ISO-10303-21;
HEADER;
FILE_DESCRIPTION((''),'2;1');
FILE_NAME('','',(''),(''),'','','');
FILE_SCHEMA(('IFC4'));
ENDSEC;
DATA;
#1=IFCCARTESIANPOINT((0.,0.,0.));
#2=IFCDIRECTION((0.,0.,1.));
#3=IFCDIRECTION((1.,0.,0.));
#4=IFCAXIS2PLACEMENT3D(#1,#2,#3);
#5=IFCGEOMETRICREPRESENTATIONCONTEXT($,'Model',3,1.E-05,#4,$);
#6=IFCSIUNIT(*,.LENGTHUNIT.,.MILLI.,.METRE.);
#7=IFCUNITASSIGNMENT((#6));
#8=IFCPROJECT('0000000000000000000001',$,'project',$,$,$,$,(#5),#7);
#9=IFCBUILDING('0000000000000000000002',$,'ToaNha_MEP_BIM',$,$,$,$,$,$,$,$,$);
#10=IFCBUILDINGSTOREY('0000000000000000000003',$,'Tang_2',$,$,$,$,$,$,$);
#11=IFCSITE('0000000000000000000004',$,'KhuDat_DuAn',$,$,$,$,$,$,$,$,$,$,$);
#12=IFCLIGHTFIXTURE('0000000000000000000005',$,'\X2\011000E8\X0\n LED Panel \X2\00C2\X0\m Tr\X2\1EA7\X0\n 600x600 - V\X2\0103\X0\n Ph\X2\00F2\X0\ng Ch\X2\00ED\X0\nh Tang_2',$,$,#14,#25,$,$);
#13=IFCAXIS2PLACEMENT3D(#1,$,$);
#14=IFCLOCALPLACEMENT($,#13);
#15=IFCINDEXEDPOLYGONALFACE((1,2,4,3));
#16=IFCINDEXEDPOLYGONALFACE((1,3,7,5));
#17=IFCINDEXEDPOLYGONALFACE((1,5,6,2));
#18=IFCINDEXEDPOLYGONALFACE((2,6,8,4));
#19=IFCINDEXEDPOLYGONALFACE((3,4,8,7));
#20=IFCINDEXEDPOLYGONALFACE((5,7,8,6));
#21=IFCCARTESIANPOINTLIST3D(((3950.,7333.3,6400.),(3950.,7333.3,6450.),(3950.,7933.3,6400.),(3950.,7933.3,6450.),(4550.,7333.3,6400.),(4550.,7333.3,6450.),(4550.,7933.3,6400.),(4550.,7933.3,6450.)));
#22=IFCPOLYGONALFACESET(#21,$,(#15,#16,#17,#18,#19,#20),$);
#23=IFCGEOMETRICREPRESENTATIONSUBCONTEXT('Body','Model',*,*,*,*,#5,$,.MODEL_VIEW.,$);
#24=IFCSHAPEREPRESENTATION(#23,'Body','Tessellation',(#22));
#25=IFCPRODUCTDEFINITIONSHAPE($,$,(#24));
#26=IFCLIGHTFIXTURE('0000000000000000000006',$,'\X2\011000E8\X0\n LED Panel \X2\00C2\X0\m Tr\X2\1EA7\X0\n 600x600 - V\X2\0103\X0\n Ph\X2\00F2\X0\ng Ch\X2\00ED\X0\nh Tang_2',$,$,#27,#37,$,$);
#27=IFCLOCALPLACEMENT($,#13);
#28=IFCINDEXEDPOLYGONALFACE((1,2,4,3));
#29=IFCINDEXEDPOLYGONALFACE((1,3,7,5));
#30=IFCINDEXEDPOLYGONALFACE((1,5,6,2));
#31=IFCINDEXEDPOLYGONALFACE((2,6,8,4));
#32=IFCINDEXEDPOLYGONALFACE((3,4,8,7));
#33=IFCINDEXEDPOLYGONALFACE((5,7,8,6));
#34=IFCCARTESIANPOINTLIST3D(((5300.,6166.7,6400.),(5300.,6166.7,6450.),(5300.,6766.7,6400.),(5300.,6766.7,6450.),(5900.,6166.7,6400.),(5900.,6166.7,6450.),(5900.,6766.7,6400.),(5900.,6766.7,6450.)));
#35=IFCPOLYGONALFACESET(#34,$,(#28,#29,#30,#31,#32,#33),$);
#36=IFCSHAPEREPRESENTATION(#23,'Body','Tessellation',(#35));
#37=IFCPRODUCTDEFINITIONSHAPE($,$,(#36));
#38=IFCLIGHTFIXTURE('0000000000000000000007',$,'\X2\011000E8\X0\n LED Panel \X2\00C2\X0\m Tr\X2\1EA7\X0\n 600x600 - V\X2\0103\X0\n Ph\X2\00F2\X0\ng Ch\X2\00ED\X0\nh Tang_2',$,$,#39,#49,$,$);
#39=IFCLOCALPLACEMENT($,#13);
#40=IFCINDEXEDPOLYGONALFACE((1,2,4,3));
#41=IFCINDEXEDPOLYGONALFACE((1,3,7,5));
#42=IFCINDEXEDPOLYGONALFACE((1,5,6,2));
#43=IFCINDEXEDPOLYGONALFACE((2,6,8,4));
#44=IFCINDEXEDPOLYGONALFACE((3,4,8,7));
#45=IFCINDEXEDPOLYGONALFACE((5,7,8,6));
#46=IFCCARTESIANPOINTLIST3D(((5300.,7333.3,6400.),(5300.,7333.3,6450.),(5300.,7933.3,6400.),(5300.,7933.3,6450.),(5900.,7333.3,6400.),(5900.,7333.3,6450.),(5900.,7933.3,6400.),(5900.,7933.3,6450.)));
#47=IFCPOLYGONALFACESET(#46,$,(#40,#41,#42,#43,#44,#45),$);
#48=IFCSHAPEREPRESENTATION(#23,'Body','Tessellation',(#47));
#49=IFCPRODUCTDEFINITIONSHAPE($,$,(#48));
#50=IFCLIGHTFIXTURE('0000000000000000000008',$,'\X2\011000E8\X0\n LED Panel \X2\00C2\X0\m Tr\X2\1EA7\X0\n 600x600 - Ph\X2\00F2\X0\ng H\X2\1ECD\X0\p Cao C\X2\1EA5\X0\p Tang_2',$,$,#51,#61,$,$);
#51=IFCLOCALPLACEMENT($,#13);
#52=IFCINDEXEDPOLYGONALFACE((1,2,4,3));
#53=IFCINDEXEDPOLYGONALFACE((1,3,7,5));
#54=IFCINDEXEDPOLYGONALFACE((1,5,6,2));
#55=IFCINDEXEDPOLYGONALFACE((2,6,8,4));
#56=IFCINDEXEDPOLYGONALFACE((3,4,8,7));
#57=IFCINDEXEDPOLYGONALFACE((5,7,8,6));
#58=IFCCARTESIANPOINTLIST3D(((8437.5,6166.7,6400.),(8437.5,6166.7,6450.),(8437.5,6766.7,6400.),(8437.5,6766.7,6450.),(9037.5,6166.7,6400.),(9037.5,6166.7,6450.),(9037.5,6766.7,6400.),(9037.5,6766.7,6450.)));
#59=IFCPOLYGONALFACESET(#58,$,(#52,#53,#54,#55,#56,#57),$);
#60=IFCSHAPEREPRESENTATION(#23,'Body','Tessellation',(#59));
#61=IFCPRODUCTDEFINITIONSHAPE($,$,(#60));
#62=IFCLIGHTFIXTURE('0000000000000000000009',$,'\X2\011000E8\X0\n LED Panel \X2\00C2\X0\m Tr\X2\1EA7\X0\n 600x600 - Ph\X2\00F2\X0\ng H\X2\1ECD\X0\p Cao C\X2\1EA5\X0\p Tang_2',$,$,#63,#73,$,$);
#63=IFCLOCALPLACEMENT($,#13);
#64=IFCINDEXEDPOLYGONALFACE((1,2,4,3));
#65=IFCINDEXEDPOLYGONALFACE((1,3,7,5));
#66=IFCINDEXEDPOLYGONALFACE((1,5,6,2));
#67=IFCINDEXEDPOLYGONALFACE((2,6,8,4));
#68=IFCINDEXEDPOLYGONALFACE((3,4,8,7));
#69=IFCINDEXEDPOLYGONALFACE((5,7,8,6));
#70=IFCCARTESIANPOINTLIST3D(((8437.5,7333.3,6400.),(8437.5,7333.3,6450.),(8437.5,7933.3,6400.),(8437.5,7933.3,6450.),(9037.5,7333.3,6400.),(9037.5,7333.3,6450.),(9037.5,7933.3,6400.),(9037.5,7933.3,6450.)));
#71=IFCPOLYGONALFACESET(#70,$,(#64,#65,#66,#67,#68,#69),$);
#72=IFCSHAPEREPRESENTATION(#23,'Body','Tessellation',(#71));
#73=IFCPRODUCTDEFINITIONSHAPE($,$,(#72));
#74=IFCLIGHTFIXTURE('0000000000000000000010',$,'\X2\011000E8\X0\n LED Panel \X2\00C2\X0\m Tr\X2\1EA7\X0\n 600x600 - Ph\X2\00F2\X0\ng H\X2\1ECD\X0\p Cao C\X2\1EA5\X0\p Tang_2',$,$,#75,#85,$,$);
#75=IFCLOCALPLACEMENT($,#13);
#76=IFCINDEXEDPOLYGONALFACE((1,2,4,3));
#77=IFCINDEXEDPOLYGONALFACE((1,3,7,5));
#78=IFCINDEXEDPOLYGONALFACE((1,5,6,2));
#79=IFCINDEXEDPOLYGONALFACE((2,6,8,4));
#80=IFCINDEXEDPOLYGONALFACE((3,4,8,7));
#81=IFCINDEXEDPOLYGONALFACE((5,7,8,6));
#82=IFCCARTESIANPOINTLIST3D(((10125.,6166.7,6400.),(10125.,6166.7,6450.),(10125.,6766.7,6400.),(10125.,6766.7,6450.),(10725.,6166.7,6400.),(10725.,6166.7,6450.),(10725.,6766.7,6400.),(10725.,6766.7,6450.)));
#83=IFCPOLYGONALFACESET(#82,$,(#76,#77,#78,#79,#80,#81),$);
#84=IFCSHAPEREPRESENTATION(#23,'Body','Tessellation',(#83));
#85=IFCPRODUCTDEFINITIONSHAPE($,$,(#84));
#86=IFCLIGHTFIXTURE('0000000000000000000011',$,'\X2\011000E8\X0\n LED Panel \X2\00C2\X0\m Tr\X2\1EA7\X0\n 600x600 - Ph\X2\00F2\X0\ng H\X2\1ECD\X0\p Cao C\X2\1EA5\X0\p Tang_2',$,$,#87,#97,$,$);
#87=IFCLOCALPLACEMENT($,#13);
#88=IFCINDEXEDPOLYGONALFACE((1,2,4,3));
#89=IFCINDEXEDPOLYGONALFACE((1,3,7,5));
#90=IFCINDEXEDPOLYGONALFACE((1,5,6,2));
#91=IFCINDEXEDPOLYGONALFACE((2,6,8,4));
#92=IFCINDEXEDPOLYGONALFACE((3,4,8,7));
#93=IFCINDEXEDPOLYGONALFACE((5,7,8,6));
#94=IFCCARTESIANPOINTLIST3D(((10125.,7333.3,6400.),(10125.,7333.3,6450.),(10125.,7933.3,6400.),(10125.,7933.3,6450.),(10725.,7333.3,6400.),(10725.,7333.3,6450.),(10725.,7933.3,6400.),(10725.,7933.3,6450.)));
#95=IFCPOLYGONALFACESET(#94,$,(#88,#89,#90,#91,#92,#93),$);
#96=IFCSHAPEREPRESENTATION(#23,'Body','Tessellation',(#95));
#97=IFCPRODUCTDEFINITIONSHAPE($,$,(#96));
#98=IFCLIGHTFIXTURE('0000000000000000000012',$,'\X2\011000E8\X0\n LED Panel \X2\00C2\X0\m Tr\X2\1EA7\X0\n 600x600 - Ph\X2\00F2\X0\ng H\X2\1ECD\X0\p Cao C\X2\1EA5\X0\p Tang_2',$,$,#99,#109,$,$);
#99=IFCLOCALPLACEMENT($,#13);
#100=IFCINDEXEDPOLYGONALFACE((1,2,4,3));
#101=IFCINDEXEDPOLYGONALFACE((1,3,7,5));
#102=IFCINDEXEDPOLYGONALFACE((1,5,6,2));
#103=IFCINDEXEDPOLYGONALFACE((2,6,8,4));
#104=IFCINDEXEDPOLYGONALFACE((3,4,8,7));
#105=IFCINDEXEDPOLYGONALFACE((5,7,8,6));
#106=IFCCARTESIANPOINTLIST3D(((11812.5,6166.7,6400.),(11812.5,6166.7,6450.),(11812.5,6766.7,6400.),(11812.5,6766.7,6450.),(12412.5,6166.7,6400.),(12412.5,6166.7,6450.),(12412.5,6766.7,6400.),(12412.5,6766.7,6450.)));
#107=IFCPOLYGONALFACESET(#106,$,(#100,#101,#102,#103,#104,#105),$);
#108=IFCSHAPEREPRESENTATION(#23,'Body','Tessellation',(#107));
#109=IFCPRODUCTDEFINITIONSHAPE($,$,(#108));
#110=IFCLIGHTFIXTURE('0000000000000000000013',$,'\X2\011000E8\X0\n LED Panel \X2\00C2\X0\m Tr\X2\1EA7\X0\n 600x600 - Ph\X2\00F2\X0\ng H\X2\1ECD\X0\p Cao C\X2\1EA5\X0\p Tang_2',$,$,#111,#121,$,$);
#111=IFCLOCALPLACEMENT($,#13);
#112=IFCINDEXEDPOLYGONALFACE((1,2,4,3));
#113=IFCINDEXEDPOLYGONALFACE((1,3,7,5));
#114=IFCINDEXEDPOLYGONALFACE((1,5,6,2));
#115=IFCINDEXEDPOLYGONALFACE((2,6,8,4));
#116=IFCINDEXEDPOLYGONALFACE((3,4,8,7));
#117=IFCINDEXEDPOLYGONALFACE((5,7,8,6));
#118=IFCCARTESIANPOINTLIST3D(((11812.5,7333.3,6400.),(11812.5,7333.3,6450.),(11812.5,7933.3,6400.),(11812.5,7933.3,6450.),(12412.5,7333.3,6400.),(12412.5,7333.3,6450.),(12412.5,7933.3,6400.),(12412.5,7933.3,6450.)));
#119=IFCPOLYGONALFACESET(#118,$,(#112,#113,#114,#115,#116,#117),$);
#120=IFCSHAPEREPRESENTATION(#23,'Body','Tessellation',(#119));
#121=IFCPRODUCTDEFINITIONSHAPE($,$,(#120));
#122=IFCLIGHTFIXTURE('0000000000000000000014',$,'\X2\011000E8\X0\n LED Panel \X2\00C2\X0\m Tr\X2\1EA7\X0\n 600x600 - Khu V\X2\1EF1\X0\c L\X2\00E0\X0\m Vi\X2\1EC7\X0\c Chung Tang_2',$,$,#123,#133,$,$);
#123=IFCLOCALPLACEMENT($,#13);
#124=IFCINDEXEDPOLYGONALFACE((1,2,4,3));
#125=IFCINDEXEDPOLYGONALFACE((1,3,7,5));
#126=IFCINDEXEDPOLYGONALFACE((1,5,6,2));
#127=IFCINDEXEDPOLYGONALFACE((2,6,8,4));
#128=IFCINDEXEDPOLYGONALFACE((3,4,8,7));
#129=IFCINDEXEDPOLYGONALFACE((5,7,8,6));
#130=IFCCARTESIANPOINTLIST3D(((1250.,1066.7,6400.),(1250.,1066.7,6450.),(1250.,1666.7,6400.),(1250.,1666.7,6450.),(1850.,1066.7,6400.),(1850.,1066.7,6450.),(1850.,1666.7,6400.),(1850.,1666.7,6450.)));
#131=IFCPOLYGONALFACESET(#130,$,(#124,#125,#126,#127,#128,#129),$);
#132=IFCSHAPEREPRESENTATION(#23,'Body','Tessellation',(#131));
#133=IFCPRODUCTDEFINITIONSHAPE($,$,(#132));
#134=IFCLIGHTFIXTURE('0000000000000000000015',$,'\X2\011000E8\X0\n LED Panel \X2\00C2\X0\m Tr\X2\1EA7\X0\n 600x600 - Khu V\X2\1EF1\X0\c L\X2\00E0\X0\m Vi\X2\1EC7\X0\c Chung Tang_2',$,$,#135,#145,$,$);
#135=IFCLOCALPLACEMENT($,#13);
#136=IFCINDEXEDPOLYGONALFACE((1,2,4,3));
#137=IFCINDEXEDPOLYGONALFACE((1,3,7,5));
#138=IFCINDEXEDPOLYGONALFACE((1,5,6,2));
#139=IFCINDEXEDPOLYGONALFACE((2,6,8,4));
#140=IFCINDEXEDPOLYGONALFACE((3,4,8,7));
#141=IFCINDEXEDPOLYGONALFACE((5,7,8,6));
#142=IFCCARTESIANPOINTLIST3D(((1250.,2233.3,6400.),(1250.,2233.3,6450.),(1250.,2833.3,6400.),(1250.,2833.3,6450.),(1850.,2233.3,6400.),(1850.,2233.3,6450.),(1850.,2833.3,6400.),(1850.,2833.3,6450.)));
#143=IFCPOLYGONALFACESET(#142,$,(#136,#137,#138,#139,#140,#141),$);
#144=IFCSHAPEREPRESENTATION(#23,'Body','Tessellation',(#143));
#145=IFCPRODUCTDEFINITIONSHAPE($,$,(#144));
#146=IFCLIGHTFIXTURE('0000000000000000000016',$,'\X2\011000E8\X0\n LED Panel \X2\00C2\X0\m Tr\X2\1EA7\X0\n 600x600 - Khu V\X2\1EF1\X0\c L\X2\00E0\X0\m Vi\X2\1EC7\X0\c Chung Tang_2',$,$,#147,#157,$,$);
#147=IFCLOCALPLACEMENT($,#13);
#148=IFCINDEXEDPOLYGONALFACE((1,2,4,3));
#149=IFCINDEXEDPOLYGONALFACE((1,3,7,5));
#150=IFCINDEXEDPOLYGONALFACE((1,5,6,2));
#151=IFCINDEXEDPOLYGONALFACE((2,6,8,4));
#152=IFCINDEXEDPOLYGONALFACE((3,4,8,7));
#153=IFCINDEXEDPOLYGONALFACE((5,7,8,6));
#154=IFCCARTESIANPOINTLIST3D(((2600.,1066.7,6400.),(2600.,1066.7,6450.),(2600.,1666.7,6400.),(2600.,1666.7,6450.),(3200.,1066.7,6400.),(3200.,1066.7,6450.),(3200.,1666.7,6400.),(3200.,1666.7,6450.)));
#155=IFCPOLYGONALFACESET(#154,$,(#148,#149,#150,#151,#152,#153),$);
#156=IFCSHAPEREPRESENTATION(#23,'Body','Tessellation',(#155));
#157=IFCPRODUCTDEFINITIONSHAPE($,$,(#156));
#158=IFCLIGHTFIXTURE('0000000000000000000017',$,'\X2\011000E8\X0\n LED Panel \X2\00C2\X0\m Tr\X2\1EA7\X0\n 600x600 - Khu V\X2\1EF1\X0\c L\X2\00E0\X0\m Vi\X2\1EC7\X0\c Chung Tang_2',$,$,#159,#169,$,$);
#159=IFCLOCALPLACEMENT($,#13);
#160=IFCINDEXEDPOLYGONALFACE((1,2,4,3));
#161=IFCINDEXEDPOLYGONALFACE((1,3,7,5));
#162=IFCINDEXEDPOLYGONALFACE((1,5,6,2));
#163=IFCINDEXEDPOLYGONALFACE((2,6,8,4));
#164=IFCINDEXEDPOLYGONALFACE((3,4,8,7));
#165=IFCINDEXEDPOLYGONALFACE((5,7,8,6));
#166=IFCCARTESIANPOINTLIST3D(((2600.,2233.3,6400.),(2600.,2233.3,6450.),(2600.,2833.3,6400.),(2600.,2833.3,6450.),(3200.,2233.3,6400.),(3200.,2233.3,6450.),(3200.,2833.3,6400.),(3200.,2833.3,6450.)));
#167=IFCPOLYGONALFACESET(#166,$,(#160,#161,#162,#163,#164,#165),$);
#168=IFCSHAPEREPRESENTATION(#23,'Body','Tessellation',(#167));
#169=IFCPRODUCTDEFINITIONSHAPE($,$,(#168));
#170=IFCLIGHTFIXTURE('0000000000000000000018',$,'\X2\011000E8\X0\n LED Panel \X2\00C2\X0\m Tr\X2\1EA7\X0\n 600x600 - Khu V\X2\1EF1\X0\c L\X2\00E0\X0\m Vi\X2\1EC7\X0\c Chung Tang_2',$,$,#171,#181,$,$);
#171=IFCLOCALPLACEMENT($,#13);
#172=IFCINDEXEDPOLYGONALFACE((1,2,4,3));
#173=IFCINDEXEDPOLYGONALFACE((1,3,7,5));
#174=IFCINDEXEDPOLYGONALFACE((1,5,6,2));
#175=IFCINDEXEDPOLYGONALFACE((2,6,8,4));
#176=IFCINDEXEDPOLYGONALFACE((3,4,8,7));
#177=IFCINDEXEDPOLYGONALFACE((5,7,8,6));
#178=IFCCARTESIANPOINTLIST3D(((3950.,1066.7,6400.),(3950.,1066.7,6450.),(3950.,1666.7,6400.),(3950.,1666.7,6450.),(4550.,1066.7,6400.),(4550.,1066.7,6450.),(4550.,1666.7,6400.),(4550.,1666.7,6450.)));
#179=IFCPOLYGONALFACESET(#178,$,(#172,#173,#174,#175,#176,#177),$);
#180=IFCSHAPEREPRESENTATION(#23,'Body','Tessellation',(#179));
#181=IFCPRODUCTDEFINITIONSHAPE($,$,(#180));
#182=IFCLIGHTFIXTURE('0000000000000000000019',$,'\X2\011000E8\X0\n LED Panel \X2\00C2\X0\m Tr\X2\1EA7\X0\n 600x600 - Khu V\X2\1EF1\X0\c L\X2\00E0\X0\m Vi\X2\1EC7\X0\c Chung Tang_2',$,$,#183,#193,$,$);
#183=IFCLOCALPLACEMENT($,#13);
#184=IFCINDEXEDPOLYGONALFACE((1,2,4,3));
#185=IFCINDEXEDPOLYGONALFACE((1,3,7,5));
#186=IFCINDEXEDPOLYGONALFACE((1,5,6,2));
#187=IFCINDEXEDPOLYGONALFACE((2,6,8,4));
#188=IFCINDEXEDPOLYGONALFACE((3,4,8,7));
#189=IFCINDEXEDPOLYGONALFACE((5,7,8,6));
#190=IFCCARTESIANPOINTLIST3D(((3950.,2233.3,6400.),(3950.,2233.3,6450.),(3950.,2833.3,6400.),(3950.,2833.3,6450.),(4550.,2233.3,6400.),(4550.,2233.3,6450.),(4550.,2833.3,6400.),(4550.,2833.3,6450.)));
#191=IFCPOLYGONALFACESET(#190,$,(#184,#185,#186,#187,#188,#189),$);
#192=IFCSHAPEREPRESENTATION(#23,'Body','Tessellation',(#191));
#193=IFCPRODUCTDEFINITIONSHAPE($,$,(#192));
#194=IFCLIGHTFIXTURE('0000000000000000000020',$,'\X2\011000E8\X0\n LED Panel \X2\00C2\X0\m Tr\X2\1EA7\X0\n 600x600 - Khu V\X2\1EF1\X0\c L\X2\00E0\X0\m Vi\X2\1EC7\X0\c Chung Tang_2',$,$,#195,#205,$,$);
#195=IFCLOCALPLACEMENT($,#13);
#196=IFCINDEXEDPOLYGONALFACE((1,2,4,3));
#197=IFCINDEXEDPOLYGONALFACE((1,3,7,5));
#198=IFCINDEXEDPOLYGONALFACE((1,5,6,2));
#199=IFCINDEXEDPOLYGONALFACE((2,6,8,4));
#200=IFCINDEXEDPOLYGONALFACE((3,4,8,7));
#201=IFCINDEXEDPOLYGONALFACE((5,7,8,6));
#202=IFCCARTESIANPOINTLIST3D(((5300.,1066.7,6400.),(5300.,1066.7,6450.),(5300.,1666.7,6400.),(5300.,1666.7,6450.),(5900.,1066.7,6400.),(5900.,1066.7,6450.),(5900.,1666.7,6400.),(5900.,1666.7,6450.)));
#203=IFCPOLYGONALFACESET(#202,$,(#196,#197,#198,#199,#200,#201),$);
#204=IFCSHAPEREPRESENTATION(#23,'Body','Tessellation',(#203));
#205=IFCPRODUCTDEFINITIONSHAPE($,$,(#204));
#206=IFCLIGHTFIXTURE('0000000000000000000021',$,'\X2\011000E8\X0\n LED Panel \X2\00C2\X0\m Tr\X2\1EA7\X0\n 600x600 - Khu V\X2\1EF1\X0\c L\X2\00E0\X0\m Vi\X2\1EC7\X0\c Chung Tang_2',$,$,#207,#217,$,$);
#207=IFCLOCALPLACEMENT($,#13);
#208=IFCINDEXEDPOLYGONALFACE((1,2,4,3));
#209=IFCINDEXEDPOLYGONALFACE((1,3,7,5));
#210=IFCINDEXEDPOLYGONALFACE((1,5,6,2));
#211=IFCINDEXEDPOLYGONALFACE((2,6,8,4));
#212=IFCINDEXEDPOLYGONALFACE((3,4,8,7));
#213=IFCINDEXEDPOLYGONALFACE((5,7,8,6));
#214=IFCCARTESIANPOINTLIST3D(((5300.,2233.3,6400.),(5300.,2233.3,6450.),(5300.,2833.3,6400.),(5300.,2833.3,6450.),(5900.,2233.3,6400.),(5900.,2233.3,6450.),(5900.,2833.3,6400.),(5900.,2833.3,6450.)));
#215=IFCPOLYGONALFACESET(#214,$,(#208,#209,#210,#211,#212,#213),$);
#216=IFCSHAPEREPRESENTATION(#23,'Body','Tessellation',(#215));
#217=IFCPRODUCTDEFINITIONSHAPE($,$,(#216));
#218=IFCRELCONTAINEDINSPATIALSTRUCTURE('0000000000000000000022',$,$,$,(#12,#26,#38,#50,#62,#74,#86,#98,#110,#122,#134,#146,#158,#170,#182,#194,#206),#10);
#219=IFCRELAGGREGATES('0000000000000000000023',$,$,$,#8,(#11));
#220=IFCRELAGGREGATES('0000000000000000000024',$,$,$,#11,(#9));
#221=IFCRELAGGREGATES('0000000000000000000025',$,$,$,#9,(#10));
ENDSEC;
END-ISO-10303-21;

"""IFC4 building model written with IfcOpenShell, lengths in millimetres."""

from ifc_helpers import new_model, si_unit, frame, origin_with_axes, context, subcontext, project, spatial, polyline, outline, extrude, element, save


model = new_model("IFC4")

# Units and contexts
model_context = context("Model", 3, precision=1e-05, world=origin_with_axes())
body_context = subcontext(model_context, "Body", "Model", "MODEL_VIEW")
ifc_project = project(units=[si_unit("LENGTHUNIT", "METRE", prefix="MILLI")], contexts=[model_context])

# Site, building, storey
site = spatial("IfcSite", under=ifc_project, Name="KhuDat_DuAn")
building = spatial("IfcBuilding", under=site, Name="ToaNha_MEP_BIM")
storey = spatial("IfcBuildingStorey", under=building, Name="Tang_2")

# Light fixtures
element("IfcLightFixture", 1, inside=storey, Name="Đèn LED Panel Âm Trần 600x600 - Văn Phòng Chính Tang_2", context=body_context, shape_type="SweptSolid", body=[
    extrude(outline(polyline([(3950.0, 7333.3), (4550.0, 7333.3), (4550.0, 7933.3), (3950.0, 7933.3), (3950.0, 7333.3)])), frame((0.0, 0.0, 6400.0), z_axis=(0.0, 0.0, 1.0), x_axis=(1.0, 0.0, 0.0)), (0.0, 0.0, 1.0), 50.0),
])
element("IfcLightFixture", 2, inside=storey, Name="Đèn LED Panel Âm Trần 600x600 - Văn Phòng Chính Tang_2", context=body_context, shape_type="SweptSolid", body=[
    extrude(outline(polyline([(5300.0, 6166.7), (5900.0, 6166.7), (5900.0, 6766.7), (5300.0, 6766.7), (5300.0, 6166.7)])), frame((0.0, 0.0, 6400.0), z_axis=(0.0, 0.0, 1.0), x_axis=(1.0, 0.0, 0.0)), (0.0, 0.0, 1.0), 50.0),
])
element("IfcLightFixture", 3, inside=storey, Name="Đèn LED Panel Âm Trần 600x600 - Văn Phòng Chính Tang_2", context=body_context, shape_type="SweptSolid", body=[
    extrude(outline(polyline([(5300.0, 7333.3), (5900.0, 7333.3), (5900.0, 7933.3), (5300.0, 7933.3), (5300.0, 7333.3)])), frame((0.0, 0.0, 6400.0), z_axis=(0.0, 0.0, 1.0), x_axis=(1.0, 0.0, 0.0)), (0.0, 0.0, 1.0), 50.0),
])
element("IfcLightFixture", 4, inside=storey, Name="Đèn LED Panel Âm Trần 600x600 - Phòng Họp Cao Cấp Tang_2", context=body_context, shape_type="SweptSolid", body=[
    extrude(outline(polyline([(8437.5, 6166.7), (9037.5, 6166.7), (9037.5, 6766.7), (8437.5, 6766.7), (8437.5, 6166.7)])), frame((0.0, 0.0, 6400.0), z_axis=(0.0, 0.0, 1.0), x_axis=(1.0, 0.0, 0.0)), (0.0, 0.0, 1.0), 50.0),
])
element("IfcLightFixture", 5, inside=storey, Name="Đèn LED Panel Âm Trần 600x600 - Phòng Họp Cao Cấp Tang_2", context=body_context, shape_type="SweptSolid", body=[
    extrude(outline(polyline([(8437.5, 7333.3), (9037.5, 7333.3), (9037.5, 7933.3), (8437.5, 7933.3), (8437.5, 7333.3)])), frame((0.0, 0.0, 6400.0), z_axis=(0.0, 0.0, 1.0), x_axis=(1.0, 0.0, 0.0)), (0.0, 0.0, 1.0), 50.0),
])
element("IfcLightFixture", 6, inside=storey, Name="Đèn LED Panel Âm Trần 600x600 - Phòng Họp Cao Cấp Tang_2", context=body_context, shape_type="SweptSolid", body=[
    extrude(outline(polyline([(10125.0, 6166.7), (10725.0, 6166.7), (10725.0, 6766.7), (10125.0, 6766.7), (10125.0, 6166.7)])), frame((0.0, 0.0, 6400.0), z_axis=(0.0, 0.0, 1.0), x_axis=(1.0, 0.0, 0.0)), (0.0, 0.0, 1.0), 50.0),
])
element("IfcLightFixture", 7, inside=storey, Name="Đèn LED Panel Âm Trần 600x600 - Phòng Họp Cao Cấp Tang_2", context=body_context, shape_type="SweptSolid", body=[
    extrude(outline(polyline([(10125.0, 7333.3), (10725.0, 7333.3), (10725.0, 7933.3), (10125.0, 7933.3), (10125.0, 7333.3)])), frame((0.0, 0.0, 6400.0), z_axis=(0.0, 0.0, 1.0), x_axis=(1.0, 0.0, 0.0)), (0.0, 0.0, 1.0), 50.0),
])
element("IfcLightFixture", 8, inside=storey, Name="Đèn LED Panel Âm Trần 600x600 - Phòng Họp Cao Cấp Tang_2", context=body_context, shape_type="SweptSolid", body=[
    extrude(outline(polyline([(11812.5, 6166.7), (12412.5, 6166.7), (12412.5, 6766.7), (11812.5, 6766.7), (11812.5, 6166.7)])), frame((0.0, 0.0, 6400.0), z_axis=(0.0, 0.0, 1.0), x_axis=(1.0, 0.0, 0.0)), (0.0, 0.0, 1.0), 50.0),
])
element("IfcLightFixture", 9, inside=storey, Name="Đèn LED Panel Âm Trần 600x600 - Phòng Họp Cao Cấp Tang_2", context=body_context, shape_type="SweptSolid", body=[
    extrude(outline(polyline([(11812.5, 7333.3), (12412.5, 7333.3), (12412.5, 7933.3), (11812.5, 7933.3), (11812.5, 7333.3)])), frame((0.0, 0.0, 6400.0), z_axis=(0.0, 0.0, 1.0), x_axis=(1.0, 0.0, 0.0)), (0.0, 0.0, 1.0), 50.0),
])
element("IfcLightFixture", 10, inside=storey, Name="Đèn LED Panel Âm Trần 600x600 - Khu Vực Làm Việc Chung Tang_2", context=body_context, shape_type="SweptSolid", body=[
    extrude(outline(polyline([(1250.0, 1066.7), (1850.0, 1066.7), (1850.0, 1666.7), (1250.0, 1666.7), (1250.0, 1066.7)])), frame((0.0, 0.0, 6400.0), z_axis=(0.0, 0.0, 1.0), x_axis=(1.0, 0.0, 0.0)), (0.0, 0.0, 1.0), 50.0),
])
element("IfcLightFixture", 11, inside=storey, Name="Đèn LED Panel Âm Trần 600x600 - Khu Vực Làm Việc Chung Tang_2", context=body_context, shape_type="SweptSolid", body=[
    extrude(outline(polyline([(1250.0, 2233.3), (1850.0, 2233.3), (1850.0, 2833.3), (1250.0, 2833.3), (1250.0, 2233.3)])), frame((0.0, 0.0, 6400.0), z_axis=(0.0, 0.0, 1.0), x_axis=(1.0, 0.0, 0.0)), (0.0, 0.0, 1.0), 50.0),
])
element("IfcLightFixture", 12, inside=storey, Name="Đèn LED Panel Âm Trần 600x600 - Khu Vực Làm Việc Chung Tang_2", context=body_context, shape_type="SweptSolid", body=[
    extrude(outline(polyline([(2600.0, 1066.7), (3200.0, 1066.7), (3200.0, 1666.7), (2600.0, 1666.7), (2600.0, 1066.7)])), frame((0.0, 0.0, 6400.0), z_axis=(0.0, 0.0, 1.0), x_axis=(1.0, 0.0, 0.0)), (0.0, 0.0, 1.0), 50.0),
])
element("IfcLightFixture", 13, inside=storey, Name="Đèn LED Panel Âm Trần 600x600 - Khu Vực Làm Việc Chung Tang_2", context=body_context, shape_type="SweptSolid", body=[
    extrude(outline(polyline([(2600.0, 2233.3), (3200.0, 2233.3), (3200.0, 2833.3), (2600.0, 2833.3), (2600.0, 2233.3)])), frame((0.0, 0.0, 6400.0), z_axis=(0.0, 0.0, 1.0), x_axis=(1.0, 0.0, 0.0)), (0.0, 0.0, 1.0), 50.0),
])
element("IfcLightFixture", 14, inside=storey, Name="Đèn LED Panel Âm Trần 600x600 - Khu Vực Làm Việc Chung Tang_2", context=body_context, shape_type="SweptSolid", body=[
    extrude(outline(polyline([(3950.0, 1066.7), (4550.0, 1066.7), (4550.0, 1666.7), (3950.0, 1666.7), (3950.0, 1066.7)])), frame((0.0, 0.0, 6400.0), z_axis=(0.0, 0.0, 1.0), x_axis=(1.0, 0.0, 0.0)), (0.0, 0.0, 1.0), 50.0),
])
element("IfcLightFixture", 15, inside=storey, Name="Đèn LED Panel Âm Trần 600x600 - Khu Vực Làm Việc Chung Tang_2", context=body_context, shape_type="SweptSolid", body=[
    extrude(outline(polyline([(3950.0, 2233.3), (4550.0, 2233.3), (4550.0, 2833.3), (3950.0, 2833.3), (3950.0, 2233.3)])), frame((0.0, 0.0, 6400.0), z_axis=(0.0, 0.0, 1.0), x_axis=(1.0, 0.0, 0.0)), (0.0, 0.0, 1.0), 50.0),
])
element("IfcLightFixture", 16, inside=storey, Name="Đèn LED Panel Âm Trần 600x600 - Khu Vực Làm Việc Chung Tang_2", context=body_context, shape_type="SweptSolid", body=[
    extrude(outline(polyline([(5300.0, 1066.7), (5900.0, 1066.7), (5900.0, 1666.7), (5300.0, 1666.7), (5300.0, 1066.7)])), frame((0.0, 0.0, 6400.0), z_axis=(0.0, 0.0, 1.0), x_axis=(1.0, 0.0, 0.0)), (0.0, 0.0, 1.0), 50.0),
])
element("IfcLightFixture", 17, inside=storey, Name="Đèn LED Panel Âm Trần 600x600 - Khu Vực Làm Việc Chung Tang_2", context=body_context, shape_type="SweptSolid", body=[
    extrude(outline(polyline([(5300.0, 2233.3), (5900.0, 2233.3), (5900.0, 2833.3), (5300.0, 2833.3), (5300.0, 2233.3)])), frame((0.0, 0.0, 6400.0), z_axis=(0.0, 0.0, 1.0), x_axis=(1.0, 0.0, 0.0)), (0.0, 0.0, 1.0), 50.0),
])

save(model, "model.ifc")
